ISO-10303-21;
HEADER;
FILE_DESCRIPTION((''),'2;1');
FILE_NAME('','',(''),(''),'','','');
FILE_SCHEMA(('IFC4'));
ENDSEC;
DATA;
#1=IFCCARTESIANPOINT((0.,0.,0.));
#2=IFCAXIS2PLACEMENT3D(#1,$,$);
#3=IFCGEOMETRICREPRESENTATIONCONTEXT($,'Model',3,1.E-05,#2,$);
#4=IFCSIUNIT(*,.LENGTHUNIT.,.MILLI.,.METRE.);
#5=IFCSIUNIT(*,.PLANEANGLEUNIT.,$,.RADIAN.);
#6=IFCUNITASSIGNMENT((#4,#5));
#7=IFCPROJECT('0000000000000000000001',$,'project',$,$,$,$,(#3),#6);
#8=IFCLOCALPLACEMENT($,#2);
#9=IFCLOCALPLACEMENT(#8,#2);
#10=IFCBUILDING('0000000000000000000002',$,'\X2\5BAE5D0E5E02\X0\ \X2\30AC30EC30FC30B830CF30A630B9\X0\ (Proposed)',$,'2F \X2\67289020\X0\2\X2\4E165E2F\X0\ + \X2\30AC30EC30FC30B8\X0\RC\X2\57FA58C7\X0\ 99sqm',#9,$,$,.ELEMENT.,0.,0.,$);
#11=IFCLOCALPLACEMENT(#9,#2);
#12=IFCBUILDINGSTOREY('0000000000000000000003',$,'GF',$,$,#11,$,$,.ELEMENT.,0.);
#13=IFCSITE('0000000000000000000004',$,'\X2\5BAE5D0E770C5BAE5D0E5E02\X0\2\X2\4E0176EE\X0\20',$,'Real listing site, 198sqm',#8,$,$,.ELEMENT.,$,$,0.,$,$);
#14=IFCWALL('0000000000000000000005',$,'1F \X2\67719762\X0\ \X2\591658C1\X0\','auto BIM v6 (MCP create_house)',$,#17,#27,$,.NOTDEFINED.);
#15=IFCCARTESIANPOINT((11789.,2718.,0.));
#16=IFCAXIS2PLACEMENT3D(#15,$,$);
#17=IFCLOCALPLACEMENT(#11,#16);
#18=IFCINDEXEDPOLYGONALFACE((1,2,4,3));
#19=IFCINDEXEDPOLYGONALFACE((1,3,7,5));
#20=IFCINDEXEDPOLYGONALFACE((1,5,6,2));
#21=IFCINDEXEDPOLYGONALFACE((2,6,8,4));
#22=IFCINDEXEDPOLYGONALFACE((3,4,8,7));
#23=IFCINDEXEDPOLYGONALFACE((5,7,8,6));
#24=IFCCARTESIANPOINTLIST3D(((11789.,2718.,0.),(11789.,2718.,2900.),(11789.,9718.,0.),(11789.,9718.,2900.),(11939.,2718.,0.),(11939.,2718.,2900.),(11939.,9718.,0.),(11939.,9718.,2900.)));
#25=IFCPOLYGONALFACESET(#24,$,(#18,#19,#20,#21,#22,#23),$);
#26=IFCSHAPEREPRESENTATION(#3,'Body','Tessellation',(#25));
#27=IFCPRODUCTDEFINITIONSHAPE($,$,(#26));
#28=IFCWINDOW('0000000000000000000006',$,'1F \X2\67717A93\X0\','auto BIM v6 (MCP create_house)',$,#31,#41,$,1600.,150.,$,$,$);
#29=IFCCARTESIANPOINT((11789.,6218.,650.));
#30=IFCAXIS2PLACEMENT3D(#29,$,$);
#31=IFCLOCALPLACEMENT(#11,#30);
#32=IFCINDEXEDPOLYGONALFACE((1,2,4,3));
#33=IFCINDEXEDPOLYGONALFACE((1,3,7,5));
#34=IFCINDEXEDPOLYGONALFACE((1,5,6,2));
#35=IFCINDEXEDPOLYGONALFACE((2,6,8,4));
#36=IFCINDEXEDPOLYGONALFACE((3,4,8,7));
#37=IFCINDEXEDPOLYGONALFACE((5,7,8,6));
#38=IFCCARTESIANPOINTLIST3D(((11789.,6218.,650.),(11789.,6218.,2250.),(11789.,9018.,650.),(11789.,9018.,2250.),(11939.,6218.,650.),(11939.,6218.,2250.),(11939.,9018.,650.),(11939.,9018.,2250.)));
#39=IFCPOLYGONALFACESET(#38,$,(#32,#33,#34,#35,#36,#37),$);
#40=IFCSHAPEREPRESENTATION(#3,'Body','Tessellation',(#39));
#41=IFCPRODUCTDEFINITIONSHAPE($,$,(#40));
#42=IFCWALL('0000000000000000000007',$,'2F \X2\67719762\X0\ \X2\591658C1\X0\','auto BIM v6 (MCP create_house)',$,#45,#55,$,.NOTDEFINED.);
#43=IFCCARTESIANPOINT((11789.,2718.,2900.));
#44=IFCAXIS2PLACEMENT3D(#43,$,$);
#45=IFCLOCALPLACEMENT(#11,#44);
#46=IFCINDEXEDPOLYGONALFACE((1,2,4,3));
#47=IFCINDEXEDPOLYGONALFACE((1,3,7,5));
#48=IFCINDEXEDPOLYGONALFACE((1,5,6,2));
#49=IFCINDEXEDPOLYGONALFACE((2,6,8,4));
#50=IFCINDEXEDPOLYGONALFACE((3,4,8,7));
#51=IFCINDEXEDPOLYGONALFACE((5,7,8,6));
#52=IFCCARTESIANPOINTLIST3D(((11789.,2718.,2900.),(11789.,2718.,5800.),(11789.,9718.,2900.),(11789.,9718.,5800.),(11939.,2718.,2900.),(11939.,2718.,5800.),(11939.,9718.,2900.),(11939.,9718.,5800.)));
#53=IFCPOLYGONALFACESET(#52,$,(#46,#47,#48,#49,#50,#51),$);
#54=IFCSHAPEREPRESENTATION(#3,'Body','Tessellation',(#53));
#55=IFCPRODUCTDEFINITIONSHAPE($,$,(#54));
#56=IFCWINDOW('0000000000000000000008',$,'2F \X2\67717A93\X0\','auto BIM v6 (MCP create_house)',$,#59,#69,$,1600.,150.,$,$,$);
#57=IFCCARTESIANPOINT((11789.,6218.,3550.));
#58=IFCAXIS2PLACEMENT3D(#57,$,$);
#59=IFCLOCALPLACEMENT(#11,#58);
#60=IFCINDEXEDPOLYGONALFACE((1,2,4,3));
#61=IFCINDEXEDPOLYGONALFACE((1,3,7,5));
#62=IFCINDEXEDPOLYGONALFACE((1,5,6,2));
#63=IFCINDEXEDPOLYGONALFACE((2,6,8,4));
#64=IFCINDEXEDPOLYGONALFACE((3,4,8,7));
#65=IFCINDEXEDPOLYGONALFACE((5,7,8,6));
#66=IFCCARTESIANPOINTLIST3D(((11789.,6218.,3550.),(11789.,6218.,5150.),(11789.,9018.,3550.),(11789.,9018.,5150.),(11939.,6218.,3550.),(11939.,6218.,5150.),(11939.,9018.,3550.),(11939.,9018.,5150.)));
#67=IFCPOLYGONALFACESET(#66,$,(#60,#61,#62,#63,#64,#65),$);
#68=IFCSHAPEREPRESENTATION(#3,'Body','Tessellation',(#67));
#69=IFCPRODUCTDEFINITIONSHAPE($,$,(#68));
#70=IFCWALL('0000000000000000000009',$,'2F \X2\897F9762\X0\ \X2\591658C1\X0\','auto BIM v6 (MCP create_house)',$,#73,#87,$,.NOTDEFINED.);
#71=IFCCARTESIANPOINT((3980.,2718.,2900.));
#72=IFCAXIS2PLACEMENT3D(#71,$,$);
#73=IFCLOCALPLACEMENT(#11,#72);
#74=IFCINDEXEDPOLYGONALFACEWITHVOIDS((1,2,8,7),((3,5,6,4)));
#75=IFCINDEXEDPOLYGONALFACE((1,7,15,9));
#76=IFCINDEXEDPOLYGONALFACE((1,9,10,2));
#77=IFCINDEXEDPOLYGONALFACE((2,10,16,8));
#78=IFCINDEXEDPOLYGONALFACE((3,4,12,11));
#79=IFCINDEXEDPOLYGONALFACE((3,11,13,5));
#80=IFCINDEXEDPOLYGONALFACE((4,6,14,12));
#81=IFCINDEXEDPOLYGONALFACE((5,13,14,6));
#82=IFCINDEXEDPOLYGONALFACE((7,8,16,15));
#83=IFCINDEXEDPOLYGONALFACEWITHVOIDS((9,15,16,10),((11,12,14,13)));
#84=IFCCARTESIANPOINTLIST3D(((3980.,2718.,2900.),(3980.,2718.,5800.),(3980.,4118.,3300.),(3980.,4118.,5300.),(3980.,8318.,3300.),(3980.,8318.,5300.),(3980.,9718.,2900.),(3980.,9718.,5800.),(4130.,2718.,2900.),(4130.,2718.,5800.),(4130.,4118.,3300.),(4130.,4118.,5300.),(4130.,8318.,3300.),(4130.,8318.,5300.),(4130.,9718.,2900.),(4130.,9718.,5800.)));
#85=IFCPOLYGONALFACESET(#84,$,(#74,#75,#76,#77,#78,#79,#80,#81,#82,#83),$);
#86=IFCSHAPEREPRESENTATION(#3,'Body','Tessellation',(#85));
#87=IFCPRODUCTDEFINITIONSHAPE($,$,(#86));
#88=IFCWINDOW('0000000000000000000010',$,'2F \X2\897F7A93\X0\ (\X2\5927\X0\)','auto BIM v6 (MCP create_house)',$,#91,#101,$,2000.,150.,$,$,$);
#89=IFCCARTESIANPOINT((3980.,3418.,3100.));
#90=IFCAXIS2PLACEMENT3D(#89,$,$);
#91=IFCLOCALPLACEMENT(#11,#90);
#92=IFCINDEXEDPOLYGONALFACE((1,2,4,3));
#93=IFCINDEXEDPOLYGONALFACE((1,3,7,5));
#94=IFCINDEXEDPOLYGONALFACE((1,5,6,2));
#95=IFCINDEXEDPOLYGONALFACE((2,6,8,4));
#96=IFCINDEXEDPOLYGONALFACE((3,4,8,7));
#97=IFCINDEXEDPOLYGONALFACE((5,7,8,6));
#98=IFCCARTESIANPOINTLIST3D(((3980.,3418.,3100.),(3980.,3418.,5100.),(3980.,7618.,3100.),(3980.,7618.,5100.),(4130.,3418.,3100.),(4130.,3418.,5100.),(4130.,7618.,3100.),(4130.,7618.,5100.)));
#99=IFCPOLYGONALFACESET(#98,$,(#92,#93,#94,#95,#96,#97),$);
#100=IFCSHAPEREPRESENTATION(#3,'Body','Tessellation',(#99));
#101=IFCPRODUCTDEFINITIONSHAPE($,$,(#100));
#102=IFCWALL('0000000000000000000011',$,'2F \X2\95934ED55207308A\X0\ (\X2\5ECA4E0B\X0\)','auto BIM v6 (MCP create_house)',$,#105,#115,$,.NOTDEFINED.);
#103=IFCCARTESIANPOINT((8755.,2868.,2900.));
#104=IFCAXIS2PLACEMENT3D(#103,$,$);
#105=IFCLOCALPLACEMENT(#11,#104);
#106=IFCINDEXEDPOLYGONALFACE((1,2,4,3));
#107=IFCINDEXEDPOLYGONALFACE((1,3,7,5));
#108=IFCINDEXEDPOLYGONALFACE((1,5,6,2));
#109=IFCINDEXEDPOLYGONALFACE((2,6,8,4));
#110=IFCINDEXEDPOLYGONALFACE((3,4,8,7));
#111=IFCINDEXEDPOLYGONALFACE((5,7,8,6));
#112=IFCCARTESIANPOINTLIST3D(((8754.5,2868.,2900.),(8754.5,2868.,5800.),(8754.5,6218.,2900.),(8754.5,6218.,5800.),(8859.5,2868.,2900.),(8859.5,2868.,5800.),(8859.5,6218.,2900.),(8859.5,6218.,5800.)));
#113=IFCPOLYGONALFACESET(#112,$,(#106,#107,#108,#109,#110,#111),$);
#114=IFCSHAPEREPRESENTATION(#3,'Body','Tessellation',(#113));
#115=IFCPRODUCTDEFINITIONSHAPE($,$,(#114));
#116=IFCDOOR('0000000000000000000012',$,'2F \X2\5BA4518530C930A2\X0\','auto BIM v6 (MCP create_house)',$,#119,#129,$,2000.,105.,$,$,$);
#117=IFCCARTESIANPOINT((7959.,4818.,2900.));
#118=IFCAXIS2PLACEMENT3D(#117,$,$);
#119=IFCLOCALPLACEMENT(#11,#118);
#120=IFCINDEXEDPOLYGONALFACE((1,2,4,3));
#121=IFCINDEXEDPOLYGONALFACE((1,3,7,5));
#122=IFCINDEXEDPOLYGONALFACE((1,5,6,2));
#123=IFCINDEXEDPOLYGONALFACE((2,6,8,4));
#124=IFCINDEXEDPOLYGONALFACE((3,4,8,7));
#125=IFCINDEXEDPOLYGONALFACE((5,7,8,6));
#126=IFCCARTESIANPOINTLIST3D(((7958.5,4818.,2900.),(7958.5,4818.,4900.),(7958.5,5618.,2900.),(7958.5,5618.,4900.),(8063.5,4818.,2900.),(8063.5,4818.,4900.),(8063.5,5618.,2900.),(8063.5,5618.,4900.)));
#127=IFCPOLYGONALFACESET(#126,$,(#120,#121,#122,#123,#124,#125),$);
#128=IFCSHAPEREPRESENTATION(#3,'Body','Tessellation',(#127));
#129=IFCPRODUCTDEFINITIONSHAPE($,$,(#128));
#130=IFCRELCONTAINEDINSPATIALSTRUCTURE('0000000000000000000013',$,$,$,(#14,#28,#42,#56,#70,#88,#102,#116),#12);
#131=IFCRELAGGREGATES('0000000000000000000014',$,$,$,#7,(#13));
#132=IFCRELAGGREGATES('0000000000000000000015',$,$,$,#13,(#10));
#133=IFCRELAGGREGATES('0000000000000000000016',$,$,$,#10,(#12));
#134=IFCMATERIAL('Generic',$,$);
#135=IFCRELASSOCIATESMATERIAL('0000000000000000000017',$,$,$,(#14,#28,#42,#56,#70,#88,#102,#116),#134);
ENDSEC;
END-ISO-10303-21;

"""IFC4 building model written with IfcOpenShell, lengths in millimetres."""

from ifc_helpers import new_model, si_unit, frame, frame_2d, origin, place, context, project, spatial, rectangle, extrude, material, element, fill, save


model = new_model("IFC4")

# Units and contexts
model_context = context("Model", 3, precision=1e-05, world=origin())
ifc_project = project(units=[si_unit("LENGTHUNIT", "METRE", prefix="MILLI"), si_unit("PLANEANGLEUNIT", "RADIAN")], contexts=[model_context])

# Site, building, storey
site_placement = place(None, origin())
site = spatial("IfcSite", under=ifc_project, at=site_placement, Name="宮崎県宮崎市2丁目20", ObjectType="Real listing site, 198sqm", CompositionType="ELEMENT", RefElevation=0.0)
building_placement = place(site_placement, origin())
building = spatial("IfcBuilding", under=site, at=building_placement, Name="宮崎市 ガレージハウス (Proposed)", ObjectType="2F 木造2世帯 + ガレージRC基壇 99sqm", CompositionType="ELEMENT", ElevationOfRefHeight=0.0, ElevationOfTerrain=0.0)
storey_placement = place(building_placement, origin())
storey = spatial("IfcBuildingStorey", under=building, at=storey_placement, Name="GF", CompositionType="ELEMENT", Elevation=0.0)

# Shared definitions
ifc_material = material(Name="Generic")

# Wall, opening, window
wall_1_placement = place(storey_placement, frame((11789.0, 2718.0, 0.0)))
wall_1 = element("IfcWall", 1, at=wall_1_placement, inside=storey, material=ifc_material, Name="1F 東面 外壁", Description="auto BIM v6 (MCP create_house)", PredefinedType="NOTDEFINED", context=model_context, shape_type="SweptSolid", body=[
    extrude(rectangle(XDim=150.0, YDim=7000.0, at=frame_2d((75.0, 3500.0))), frame((11789.0, 2718.0, 0.0)), (0.0, 0.0, 1.0), 2900.0),
])
opening_1_placement = place(storey_placement, frame((11789.0, 6218.0, 650.0)))
opening_1 = element("IfcOpeningElement", 2, at=opening_1_placement, cuts=wall_1, PredefinedType="NOTDEFINED", context=model_context, shape_type="SweptSolid", body=[
    extrude(rectangle(XDim=150.0, YDim=2800.0, at=frame_2d((75.0, 1400.0))), frame((11789.0, 6218.0, 650.0)), (0.0, 0.0, 1.0), 1600.0),
])
window_1_placement = place(storey_placement, frame((11789.0, 6218.0, 650.0)))
window_1 = element("IfcWindow", 3, at=window_1_placement, inside=storey, material=ifc_material, Name="1F 東窓", Description="auto BIM v6 (MCP create_house)", OverallHeight=1600.0, OverallWidth=150.0, context=model_context, shape_type="SweptSolid", body=[
    extrude(rectangle(XDim=150.0, YDim=2800.0, at=frame_2d((75.0, 1400.0))), frame((11789.0, 6218.0, 650.0)), (0.0, 0.0, 1.0), 1600.0),
])
fill(opening_1, window_1)

# Walls, openings, windows
wall_2_placement = place(storey_placement, frame((11789.0, 2718.0, 2900.0)))
wall_2 = element("IfcWall", 4, at=wall_2_placement, inside=storey, material=ifc_material, Name="2F 東面 外壁", Description="auto BIM v6 (MCP create_house)", PredefinedType="NOTDEFINED", context=model_context, shape_type="SweptSolid", body=[
    extrude(rectangle(XDim=150.0, YDim=7000.0, at=frame_2d((75.0, 3500.0))), frame((11789.0, 2718.0, 2900.0)), (0.0, 0.0, 1.0), 2900.0),
])
opening_2_placement = place(storey_placement, frame((11789.0, 6218.0, 3550.0)))
opening_2 = element("IfcOpeningElement", 5, at=opening_2_placement, cuts=wall_2, PredefinedType="NOTDEFINED", context=model_context, shape_type="SweptSolid", body=[
    extrude(rectangle(XDim=150.0, YDim=2800.0, at=frame_2d((75.0, 1400.0))), frame((11789.0, 6218.0, 3550.0)), (0.0, 0.0, 1.0), 1600.0),
])
window_2_placement = place(storey_placement, frame((11789.0, 6218.0, 3550.0)))
window_2 = element("IfcWindow", 6, at=window_2_placement, inside=storey, material=ifc_material, Name="2F 東窓", Description="auto BIM v6 (MCP create_house)", OverallHeight=1600.0, OverallWidth=150.0, context=model_context, shape_type="SweptSolid", body=[
    extrude(rectangle(XDim=150.0, YDim=2800.0, at=frame_2d((75.0, 1400.0))), frame((11789.0, 6218.0, 3550.0)), (0.0, 0.0, 1.0), 1600.0),
])
fill(opening_2, window_2)
wall_3_placement = place(storey_placement, frame((3980.0, 2718.0, 2900.0)))
wall_3 = element("IfcWall", 7, at=wall_3_placement, inside=storey, material=ifc_material, Name="2F 西面 外壁", Description="auto BIM v6 (MCP create_house)", PredefinedType="NOTDEFINED", context=model_context, shape_type="SweptSolid", body=[
    extrude(rectangle(XDim=150.0, YDim=7000.0, at=frame_2d((75.0, 3500.0))), frame((3980.0, 2718.0, 2900.0)), (0.0, 0.0, 1.0), 2900.0),
])
opening_3_placement = place(storey_placement, frame((3980.0, 3418.0, 3100.0)))
opening_3 = element("IfcOpeningElement", 8, at=opening_3_placement, cuts=wall_3, PredefinedType="NOTDEFINED", context=model_context, shape_type="SweptSolid", body=[
    extrude(rectangle(XDim=150.0, YDim=4200.0, at=frame_2d((75.0, 2100.0))), frame((3980.0, 3418.0, 3100.0)), (0.0, 0.0, 1.0), 2000.0),
])
window_3_placement = place(storey_placement, frame((3980.0, 3418.0, 3100.0)))
window_3 = element("IfcWindow", 9, at=window_3_placement, inside=storey, material=ifc_material, Name="2F 西窓 (大)", Description="auto BIM v6 (MCP create_house)", OverallHeight=2000.0, OverallWidth=150.0, context=model_context, shape_type="SweptSolid", body=[
    extrude(rectangle(XDim=150.0, YDim=4200.0, at=frame_2d((75.0, 2100.0))), frame((3980.0, 3418.0, 3100.0)), (0.0, 0.0, 1.0), 2000.0),
])
fill(opening_3, window_3)

# Wall
wall_4_placement = place(storey_placement, frame((8755.0, 2868.0, 2900.0)))
element("IfcWall", 10, at=wall_4_placement, inside=storey, material=ifc_material, Name="2F 間仕切り (廊下)", Description="auto BIM v6 (MCP create_house)", PredefinedType="NOTDEFINED", context=model_context, shape_type="SweptSolid", body=[
    extrude(rectangle(XDim=105.0, YDim=3350.0, at=frame_2d((52.0, 1675.0))), frame((8755.0, 2868.0, 2900.0)), (0.0, 0.0, 1.0), 2900.0),
])

# Door
door_placement = place(storey_placement, frame((7959.0, 4818.0, 2900.0)))
element("IfcDoor", 11, at=door_placement, inside=storey, material=ifc_material, Name="2F 室内ドア", Description="auto BIM v6 (MCP create_house)", OverallHeight=2000.0, OverallWidth=105.0, context=model_context, shape_type="SweptSolid", body=[
    extrude(rectangle(XDim=105.0, YDim=800.0, at=frame_2d((52.0, 400.0))), frame((7959.0, 4818.0, 2900.0)), (0.0, 0.0, 1.0), 2000.0),
])

save(model, "model.ifc")
